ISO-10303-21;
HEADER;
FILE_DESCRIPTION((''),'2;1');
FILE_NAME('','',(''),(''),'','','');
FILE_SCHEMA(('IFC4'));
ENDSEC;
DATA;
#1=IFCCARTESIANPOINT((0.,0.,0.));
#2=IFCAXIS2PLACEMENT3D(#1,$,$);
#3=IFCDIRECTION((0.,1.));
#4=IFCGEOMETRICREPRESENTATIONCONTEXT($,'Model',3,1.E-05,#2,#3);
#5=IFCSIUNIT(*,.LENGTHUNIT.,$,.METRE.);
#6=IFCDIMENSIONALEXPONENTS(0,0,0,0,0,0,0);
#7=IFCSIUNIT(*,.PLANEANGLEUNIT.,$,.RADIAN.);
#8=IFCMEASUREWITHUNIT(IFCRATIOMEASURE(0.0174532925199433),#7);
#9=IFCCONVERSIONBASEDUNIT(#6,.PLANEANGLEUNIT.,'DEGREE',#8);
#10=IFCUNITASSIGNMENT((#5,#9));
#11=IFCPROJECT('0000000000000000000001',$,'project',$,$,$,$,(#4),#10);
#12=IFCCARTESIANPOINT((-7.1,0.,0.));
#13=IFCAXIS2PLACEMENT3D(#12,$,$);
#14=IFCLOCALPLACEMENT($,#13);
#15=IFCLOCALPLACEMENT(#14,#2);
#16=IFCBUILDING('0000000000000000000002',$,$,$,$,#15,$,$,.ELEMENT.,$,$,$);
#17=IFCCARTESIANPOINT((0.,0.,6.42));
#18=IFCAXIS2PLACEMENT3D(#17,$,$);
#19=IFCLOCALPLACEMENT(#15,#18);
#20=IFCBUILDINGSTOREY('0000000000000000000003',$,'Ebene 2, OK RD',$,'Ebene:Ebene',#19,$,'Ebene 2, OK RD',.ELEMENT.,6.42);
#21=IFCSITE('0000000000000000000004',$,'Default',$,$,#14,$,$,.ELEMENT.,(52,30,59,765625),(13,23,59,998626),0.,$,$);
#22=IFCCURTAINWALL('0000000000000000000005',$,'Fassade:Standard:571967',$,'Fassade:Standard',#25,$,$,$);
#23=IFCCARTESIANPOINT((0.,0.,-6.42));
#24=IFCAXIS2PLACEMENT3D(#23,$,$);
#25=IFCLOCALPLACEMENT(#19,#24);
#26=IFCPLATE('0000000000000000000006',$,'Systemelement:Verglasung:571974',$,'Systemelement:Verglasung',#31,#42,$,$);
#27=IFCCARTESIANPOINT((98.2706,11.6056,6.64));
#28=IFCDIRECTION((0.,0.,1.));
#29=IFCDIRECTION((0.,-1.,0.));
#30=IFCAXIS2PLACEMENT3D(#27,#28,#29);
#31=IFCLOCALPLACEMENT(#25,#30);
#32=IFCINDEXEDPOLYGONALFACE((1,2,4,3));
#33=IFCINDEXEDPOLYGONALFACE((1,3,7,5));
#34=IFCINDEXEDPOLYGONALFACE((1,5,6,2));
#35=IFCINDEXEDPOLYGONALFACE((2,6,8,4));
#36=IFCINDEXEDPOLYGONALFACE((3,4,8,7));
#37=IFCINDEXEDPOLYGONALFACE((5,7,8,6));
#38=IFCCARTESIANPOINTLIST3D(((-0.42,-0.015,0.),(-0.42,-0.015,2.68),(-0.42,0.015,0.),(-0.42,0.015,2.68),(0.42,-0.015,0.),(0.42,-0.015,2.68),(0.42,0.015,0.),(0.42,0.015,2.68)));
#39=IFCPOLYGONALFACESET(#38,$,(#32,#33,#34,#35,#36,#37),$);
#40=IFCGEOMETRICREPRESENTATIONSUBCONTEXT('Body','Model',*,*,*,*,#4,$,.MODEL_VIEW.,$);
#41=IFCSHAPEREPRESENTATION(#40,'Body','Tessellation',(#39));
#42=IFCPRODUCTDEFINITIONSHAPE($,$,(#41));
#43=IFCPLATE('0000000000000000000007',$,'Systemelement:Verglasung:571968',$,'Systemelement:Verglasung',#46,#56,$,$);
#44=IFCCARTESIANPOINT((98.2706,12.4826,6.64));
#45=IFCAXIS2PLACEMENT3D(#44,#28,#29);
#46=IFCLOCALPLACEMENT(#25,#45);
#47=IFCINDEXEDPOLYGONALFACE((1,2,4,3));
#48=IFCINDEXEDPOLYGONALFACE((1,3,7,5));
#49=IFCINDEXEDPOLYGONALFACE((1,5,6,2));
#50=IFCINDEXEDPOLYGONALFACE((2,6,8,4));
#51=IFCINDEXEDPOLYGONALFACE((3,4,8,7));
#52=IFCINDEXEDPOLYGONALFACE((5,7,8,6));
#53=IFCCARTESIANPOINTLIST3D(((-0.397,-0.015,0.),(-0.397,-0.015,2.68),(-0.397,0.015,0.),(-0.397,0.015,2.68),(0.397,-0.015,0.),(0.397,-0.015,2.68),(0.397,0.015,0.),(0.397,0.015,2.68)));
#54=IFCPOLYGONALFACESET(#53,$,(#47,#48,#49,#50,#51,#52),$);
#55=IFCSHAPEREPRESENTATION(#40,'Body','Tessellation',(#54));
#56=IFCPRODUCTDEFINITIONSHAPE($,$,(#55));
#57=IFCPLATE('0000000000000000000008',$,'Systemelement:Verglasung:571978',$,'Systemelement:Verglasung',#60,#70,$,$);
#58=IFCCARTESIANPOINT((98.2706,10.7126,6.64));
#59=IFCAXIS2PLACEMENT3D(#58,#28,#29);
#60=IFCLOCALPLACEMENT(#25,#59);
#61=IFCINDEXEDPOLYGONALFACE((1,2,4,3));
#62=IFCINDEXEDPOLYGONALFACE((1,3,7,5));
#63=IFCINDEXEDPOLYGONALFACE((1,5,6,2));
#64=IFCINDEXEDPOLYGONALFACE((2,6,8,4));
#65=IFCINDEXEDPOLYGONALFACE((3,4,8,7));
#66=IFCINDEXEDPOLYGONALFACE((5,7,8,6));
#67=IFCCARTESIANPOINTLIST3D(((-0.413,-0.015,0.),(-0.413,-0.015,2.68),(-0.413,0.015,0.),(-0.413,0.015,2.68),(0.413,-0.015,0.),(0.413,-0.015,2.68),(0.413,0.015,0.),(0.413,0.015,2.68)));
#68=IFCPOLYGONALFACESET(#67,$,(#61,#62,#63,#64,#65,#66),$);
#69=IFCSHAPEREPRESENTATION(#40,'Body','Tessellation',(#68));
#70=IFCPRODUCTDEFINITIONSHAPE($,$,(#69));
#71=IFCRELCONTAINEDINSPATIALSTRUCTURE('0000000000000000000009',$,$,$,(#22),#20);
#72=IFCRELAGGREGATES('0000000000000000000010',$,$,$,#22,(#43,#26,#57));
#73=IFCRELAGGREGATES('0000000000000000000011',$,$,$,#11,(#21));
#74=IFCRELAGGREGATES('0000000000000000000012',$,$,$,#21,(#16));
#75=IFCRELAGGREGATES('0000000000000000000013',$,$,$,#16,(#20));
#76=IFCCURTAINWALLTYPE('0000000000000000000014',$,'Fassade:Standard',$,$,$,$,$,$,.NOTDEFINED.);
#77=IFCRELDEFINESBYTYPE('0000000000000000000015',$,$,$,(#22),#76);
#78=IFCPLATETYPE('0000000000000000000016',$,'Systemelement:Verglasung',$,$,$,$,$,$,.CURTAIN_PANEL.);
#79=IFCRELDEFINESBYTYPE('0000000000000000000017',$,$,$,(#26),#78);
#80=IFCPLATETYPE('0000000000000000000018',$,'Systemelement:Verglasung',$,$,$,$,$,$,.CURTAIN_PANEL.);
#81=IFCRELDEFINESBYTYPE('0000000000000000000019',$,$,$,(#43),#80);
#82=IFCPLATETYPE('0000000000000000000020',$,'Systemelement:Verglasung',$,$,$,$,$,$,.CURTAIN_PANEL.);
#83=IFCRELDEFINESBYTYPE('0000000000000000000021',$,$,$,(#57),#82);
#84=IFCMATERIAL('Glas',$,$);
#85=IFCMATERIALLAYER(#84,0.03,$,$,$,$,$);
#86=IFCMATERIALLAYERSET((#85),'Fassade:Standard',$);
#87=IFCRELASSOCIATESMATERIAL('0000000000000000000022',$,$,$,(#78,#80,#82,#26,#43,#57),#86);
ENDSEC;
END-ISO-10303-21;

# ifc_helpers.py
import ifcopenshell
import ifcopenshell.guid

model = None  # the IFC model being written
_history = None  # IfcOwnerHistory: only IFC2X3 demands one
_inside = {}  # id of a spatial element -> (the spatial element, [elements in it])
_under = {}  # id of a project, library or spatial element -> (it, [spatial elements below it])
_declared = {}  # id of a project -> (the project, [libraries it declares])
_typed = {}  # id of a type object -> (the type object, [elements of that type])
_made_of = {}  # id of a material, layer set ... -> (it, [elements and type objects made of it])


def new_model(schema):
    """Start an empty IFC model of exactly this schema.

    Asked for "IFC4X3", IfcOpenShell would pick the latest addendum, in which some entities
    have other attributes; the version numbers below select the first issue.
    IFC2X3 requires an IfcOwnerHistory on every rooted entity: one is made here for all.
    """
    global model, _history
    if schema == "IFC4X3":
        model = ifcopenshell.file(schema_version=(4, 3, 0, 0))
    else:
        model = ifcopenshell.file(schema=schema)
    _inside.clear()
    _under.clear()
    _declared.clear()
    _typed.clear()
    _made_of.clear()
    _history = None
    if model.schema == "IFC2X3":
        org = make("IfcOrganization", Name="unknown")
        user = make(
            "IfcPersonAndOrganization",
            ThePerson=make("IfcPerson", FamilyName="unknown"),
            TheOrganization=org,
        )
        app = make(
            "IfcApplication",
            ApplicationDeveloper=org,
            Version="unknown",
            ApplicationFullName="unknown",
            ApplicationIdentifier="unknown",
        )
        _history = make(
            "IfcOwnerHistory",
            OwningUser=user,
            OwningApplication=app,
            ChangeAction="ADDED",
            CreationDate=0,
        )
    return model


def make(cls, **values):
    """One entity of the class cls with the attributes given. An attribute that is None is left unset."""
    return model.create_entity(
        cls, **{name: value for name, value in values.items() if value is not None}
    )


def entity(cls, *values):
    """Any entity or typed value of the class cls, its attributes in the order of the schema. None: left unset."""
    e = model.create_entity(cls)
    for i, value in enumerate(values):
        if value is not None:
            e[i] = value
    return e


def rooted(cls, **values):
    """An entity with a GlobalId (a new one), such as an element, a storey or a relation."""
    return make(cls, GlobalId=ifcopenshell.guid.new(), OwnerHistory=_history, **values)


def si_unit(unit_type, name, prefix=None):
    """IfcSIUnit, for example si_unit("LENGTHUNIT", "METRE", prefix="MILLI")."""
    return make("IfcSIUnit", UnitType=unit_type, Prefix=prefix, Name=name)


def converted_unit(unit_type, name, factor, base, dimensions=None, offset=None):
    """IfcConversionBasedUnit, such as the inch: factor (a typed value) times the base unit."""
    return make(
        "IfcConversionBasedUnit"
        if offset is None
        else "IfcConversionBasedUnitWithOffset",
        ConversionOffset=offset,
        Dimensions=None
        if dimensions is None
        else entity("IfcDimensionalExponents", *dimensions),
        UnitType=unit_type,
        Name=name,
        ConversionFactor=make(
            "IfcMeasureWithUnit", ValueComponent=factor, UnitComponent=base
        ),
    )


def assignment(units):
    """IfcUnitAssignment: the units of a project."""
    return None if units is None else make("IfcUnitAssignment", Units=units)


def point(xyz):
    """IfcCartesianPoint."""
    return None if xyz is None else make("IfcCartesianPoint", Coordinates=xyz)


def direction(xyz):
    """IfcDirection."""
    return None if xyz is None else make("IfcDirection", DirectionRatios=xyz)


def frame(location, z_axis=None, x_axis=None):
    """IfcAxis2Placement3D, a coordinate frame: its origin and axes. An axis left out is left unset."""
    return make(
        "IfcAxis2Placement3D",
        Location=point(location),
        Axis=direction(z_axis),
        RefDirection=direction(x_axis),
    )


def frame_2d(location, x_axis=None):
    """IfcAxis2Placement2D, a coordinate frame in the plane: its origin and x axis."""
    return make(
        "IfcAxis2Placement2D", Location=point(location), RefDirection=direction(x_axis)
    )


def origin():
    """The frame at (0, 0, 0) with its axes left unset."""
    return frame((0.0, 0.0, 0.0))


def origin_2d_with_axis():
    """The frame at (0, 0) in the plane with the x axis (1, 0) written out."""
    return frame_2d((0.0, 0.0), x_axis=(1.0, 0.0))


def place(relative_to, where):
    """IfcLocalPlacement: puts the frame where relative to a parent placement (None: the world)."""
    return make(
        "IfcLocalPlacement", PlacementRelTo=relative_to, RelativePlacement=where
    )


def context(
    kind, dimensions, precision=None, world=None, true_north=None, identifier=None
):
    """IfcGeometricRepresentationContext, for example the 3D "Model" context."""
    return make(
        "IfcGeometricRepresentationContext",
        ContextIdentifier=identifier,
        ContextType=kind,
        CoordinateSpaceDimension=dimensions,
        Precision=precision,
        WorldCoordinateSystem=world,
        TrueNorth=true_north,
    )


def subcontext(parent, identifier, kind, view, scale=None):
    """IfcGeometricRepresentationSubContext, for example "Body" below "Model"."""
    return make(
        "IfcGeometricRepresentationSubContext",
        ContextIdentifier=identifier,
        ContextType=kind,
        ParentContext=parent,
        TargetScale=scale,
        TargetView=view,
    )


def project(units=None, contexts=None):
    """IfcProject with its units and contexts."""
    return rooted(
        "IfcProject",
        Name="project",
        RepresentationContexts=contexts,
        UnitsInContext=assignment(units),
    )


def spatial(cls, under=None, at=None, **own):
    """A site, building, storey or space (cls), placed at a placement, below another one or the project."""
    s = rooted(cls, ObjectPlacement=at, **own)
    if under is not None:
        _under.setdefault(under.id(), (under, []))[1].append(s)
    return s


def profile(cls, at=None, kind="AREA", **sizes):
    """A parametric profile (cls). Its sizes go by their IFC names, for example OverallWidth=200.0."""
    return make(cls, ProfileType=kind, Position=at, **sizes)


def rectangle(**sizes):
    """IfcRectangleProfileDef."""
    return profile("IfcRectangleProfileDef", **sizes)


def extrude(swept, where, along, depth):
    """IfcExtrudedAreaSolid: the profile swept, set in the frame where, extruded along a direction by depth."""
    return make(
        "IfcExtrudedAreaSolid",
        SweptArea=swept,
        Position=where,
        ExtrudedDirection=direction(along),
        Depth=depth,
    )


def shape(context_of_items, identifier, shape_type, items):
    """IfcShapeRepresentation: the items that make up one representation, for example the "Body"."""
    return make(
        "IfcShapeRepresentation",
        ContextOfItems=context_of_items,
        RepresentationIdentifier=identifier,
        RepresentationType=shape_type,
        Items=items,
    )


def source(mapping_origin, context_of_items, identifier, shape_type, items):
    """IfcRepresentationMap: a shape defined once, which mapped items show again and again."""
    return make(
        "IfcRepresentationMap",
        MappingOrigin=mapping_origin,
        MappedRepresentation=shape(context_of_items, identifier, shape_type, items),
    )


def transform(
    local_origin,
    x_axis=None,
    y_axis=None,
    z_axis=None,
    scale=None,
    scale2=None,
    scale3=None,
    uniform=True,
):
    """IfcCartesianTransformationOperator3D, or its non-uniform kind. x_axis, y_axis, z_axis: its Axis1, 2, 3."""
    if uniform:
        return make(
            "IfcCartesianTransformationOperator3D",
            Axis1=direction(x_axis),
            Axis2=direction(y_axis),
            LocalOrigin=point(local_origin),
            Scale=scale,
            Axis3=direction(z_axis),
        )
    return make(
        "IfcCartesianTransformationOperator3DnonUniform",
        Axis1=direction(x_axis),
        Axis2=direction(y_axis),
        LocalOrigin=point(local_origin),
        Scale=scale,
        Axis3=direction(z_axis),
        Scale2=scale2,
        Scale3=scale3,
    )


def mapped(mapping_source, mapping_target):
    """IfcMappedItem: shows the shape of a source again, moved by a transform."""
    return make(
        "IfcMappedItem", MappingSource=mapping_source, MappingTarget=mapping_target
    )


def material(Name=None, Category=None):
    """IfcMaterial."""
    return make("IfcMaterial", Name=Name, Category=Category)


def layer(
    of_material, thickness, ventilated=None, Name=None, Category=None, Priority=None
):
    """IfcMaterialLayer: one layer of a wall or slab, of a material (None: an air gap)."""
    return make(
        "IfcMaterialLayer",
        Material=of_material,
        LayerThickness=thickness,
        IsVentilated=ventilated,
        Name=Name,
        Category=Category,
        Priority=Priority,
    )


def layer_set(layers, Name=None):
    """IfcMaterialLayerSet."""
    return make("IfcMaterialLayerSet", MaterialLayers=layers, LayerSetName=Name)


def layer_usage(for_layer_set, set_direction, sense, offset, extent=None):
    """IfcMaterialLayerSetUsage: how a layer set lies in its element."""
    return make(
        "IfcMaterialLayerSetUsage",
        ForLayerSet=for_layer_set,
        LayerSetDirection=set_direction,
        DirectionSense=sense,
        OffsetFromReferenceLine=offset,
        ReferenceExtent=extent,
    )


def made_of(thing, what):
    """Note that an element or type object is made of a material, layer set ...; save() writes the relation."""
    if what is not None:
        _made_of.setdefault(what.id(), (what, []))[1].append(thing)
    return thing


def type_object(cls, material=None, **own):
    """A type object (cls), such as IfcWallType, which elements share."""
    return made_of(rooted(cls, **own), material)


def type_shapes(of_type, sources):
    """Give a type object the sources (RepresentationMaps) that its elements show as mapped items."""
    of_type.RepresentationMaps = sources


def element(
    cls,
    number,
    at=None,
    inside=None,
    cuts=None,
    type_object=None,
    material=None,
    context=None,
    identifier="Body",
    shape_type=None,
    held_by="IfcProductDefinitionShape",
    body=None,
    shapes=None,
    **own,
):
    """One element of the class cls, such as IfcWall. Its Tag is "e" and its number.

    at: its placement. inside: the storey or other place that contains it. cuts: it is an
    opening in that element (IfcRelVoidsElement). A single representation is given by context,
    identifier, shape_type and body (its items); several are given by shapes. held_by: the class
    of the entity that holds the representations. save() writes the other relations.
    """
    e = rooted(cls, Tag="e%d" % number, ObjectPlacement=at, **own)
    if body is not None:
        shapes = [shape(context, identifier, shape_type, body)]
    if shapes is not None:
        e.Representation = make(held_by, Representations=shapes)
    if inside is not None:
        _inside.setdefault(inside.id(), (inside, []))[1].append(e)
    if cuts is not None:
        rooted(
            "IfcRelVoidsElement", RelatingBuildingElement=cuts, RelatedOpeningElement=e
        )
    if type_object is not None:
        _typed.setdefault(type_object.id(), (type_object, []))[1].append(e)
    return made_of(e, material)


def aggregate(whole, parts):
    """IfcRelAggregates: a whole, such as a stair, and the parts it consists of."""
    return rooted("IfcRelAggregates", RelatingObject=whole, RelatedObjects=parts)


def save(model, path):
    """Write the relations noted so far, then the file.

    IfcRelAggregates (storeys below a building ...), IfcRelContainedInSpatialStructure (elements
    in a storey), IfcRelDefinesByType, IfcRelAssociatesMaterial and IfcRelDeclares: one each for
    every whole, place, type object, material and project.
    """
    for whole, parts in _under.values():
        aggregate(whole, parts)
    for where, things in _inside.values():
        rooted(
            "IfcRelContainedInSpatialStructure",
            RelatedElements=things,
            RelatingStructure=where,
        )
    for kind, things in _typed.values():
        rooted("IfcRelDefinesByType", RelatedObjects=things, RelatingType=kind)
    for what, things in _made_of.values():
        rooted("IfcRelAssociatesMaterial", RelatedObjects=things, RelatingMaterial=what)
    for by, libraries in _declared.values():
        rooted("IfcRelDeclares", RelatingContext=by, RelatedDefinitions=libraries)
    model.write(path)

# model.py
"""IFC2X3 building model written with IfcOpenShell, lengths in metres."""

from ifc_helpers import new_model, entity, si_unit, converted_unit, direction, frame, origin, origin_2d_with_axis, place, context, subcontext, project, spatial, rectangle, extrude, source, transform, mapped, material, layer, layer_set, layer_usage, type_object, type_shapes, element, aggregate, save


model = new_model("IFC2X3")

# Units and contexts
model_context = context("Model", 3, precision=1e-05, world=origin(), true_north=direction((0.0, 1.0)))
body_context = subcontext(model_context, "Body", "Model", "MODEL_VIEW")
ifc_project = project(units=[si_unit("LENGTHUNIT", "METRE"), converted_unit("PLANEANGLEUNIT", "DEGREE", entity("IfcRatioMeasure", 0.0174532925199433), si_unit("PLANEANGLEUNIT", "RADIAN"), dimensions=[0, 0, 0, 0, 0, 0, 0])], contexts=[model_context])

# Site, building, storey
site_placement = place(None, frame((-7.1, 0.0, 0.0)))
site = spatial("IfcSite", under=ifc_project, at=site_placement, Name="Default", CompositionType="ELEMENT", RefLatitude=(52, 30, 59, 765625), RefLongitude=(13, 23, 59, 998626), RefElevation=0.0)
building_placement = place(site_placement, origin())
building = spatial("IfcBuilding", under=site, at=building_placement, CompositionType="ELEMENT")
storey_placement = place(building_placement, frame((0.0, 0.0, 6.42)))
storey = spatial("IfcBuildingStorey", under=building, at=storey_placement, Name="Ebene 2, OK RD", ObjectType="Ebene:Ebene", LongName="Ebene 2, OK RD", CompositionType="ELEMENT", Elevation=6.42)

# Curtain wall, plates
curtain_wall_type = type_object("IfcCurtainWallType", Name="Fassade:Standard", PredefinedType="NOTDEFINED")
curtain_wall_placement = place(storey_placement, frame((0.0, 0.0, -6.42)))
curtain_wall = element("IfcCurtainWall", 1, at=curtain_wall_placement, inside=storey, type_object=curtain_wall_type, Name="Fassade:Standard:571967", ObjectType="Fassade:Standard")
ifc_material_1 = material(Name="Glas")
ifc_layer_1 = layer(ifc_material_1, 0.03)
ifc_layer_set_1 = layer_set([ifc_layer_1], Name="Fassade:Standard")
ifc_layer_usage_1 = layer_usage(ifc_layer_set_1, "AXIS3", "POSITIVE", 0.0)
plate_type_1 = type_object("IfcPlateType", Name="Systemelement:Verglasung", PredefinedType="CURTAIN_PANEL", material=ifc_layer_set_1)
shared_shape_1 = source(origin(), body_context, "Body", "SweptSolid", [
    extrude(rectangle(XDim=0.03, YDim=0.84, at=origin_2d_with_axis()), frame((0.0, 0.0, 0.0), z_axis=(0.0, 0.0, 1.0), x_axis=(0.0, 1.0, 0.0)), (0.0, 0.0, 1.0), 2.68),
])
type_shapes(plate_type_1, [shared_shape_1])
plate_1_placement = place(curtain_wall_placement, frame((98.2706, 11.6056, 6.64), z_axis=(0.0, 0.0, 1.0), x_axis=(0.0, -1.0, 0.0)))
plate_1 = element("IfcPlate", 2, at=plate_1_placement, type_object=plate_type_1, material=ifc_layer_usage_1, Name="Systemelement:Verglasung:571974", ObjectType="Systemelement:Verglasung", context=body_context, shape_type="MappedRepresentation", body=[
    mapped(shared_shape_1, transform((0.0, 0.0, 0.0), scale=1.0)),
])
ifc_layer_usage_2 = layer_usage(ifc_layer_set_1, "AXIS3", "POSITIVE", 0.0)
plate_type_2 = type_object("IfcPlateType", Name="Systemelement:Verglasung", PredefinedType="CURTAIN_PANEL", material=ifc_layer_set_1)
shared_shape_2 = source(origin(), body_context, "Body", "SweptSolid", [
    extrude(rectangle(XDim=0.03, YDim=0.794, at=origin_2d_with_axis()), frame((0.0, 0.0, 0.0), z_axis=(0.0, 0.0, 1.0), x_axis=(0.0, 1.0, 0.0)), (0.0, 0.0, 1.0), 2.68),
])
type_shapes(plate_type_2, [shared_shape_2])
plate_2_placement = place(curtain_wall_placement, frame((98.2706, 12.4826, 6.64), z_axis=(0.0, 0.0, 1.0), x_axis=(0.0, -1.0, 0.0)))
plate_2 = element("IfcPlate", 3, at=plate_2_placement, type_object=plate_type_2, material=ifc_layer_usage_2, Name="Systemelement:Verglasung:571968", ObjectType="Systemelement:Verglasung", context=body_context, shape_type="MappedRepresentation", body=[
    mapped(shared_shape_2, transform((0.0, 0.0, 0.0), scale=1.0)),
])
ifc_layer_usage_3 = layer_usage(ifc_layer_set_1, "AXIS3", "POSITIVE", 0.0)
plate_type_3 = type_object("IfcPlateType", Name="Systemelement:Verglasung", PredefinedType="CURTAIN_PANEL", material=ifc_layer_set_1)
shared_shape_3 = source(origin(), body_context, "Body", "SweptSolid", [
    extrude(rectangle(XDim=0.03, YDim=0.826, at=origin_2d_with_axis()), frame((0.0, 0.0, 0.0), z_axis=(0.0, 0.0, 1.0), x_axis=(0.0, 1.0, 0.0)), (0.0, 0.0, 1.0), 2.68),
])
type_shapes(plate_type_3, [shared_shape_3])
plate_3_placement = place(curtain_wall_placement, frame((98.2706, 10.7126, 6.64), z_axis=(0.0, 0.0, 1.0), x_axis=(0.0, -1.0, 0.0)))
plate_3 = element("IfcPlate", 4, at=plate_3_placement, type_object=plate_type_3, material=ifc_layer_usage_3, Name="Systemelement:Verglasung:571978", ObjectType="Systemelement:Verglasung", context=body_context, shape_type="MappedRepresentation", body=[
    mapped(shared_shape_3, transform((0.0, 0.0, 0.0), scale=1.0)),
])
aggregate(curtain_wall, [plate_2, plate_1, plate_3])

save(model, "model.ifc")
